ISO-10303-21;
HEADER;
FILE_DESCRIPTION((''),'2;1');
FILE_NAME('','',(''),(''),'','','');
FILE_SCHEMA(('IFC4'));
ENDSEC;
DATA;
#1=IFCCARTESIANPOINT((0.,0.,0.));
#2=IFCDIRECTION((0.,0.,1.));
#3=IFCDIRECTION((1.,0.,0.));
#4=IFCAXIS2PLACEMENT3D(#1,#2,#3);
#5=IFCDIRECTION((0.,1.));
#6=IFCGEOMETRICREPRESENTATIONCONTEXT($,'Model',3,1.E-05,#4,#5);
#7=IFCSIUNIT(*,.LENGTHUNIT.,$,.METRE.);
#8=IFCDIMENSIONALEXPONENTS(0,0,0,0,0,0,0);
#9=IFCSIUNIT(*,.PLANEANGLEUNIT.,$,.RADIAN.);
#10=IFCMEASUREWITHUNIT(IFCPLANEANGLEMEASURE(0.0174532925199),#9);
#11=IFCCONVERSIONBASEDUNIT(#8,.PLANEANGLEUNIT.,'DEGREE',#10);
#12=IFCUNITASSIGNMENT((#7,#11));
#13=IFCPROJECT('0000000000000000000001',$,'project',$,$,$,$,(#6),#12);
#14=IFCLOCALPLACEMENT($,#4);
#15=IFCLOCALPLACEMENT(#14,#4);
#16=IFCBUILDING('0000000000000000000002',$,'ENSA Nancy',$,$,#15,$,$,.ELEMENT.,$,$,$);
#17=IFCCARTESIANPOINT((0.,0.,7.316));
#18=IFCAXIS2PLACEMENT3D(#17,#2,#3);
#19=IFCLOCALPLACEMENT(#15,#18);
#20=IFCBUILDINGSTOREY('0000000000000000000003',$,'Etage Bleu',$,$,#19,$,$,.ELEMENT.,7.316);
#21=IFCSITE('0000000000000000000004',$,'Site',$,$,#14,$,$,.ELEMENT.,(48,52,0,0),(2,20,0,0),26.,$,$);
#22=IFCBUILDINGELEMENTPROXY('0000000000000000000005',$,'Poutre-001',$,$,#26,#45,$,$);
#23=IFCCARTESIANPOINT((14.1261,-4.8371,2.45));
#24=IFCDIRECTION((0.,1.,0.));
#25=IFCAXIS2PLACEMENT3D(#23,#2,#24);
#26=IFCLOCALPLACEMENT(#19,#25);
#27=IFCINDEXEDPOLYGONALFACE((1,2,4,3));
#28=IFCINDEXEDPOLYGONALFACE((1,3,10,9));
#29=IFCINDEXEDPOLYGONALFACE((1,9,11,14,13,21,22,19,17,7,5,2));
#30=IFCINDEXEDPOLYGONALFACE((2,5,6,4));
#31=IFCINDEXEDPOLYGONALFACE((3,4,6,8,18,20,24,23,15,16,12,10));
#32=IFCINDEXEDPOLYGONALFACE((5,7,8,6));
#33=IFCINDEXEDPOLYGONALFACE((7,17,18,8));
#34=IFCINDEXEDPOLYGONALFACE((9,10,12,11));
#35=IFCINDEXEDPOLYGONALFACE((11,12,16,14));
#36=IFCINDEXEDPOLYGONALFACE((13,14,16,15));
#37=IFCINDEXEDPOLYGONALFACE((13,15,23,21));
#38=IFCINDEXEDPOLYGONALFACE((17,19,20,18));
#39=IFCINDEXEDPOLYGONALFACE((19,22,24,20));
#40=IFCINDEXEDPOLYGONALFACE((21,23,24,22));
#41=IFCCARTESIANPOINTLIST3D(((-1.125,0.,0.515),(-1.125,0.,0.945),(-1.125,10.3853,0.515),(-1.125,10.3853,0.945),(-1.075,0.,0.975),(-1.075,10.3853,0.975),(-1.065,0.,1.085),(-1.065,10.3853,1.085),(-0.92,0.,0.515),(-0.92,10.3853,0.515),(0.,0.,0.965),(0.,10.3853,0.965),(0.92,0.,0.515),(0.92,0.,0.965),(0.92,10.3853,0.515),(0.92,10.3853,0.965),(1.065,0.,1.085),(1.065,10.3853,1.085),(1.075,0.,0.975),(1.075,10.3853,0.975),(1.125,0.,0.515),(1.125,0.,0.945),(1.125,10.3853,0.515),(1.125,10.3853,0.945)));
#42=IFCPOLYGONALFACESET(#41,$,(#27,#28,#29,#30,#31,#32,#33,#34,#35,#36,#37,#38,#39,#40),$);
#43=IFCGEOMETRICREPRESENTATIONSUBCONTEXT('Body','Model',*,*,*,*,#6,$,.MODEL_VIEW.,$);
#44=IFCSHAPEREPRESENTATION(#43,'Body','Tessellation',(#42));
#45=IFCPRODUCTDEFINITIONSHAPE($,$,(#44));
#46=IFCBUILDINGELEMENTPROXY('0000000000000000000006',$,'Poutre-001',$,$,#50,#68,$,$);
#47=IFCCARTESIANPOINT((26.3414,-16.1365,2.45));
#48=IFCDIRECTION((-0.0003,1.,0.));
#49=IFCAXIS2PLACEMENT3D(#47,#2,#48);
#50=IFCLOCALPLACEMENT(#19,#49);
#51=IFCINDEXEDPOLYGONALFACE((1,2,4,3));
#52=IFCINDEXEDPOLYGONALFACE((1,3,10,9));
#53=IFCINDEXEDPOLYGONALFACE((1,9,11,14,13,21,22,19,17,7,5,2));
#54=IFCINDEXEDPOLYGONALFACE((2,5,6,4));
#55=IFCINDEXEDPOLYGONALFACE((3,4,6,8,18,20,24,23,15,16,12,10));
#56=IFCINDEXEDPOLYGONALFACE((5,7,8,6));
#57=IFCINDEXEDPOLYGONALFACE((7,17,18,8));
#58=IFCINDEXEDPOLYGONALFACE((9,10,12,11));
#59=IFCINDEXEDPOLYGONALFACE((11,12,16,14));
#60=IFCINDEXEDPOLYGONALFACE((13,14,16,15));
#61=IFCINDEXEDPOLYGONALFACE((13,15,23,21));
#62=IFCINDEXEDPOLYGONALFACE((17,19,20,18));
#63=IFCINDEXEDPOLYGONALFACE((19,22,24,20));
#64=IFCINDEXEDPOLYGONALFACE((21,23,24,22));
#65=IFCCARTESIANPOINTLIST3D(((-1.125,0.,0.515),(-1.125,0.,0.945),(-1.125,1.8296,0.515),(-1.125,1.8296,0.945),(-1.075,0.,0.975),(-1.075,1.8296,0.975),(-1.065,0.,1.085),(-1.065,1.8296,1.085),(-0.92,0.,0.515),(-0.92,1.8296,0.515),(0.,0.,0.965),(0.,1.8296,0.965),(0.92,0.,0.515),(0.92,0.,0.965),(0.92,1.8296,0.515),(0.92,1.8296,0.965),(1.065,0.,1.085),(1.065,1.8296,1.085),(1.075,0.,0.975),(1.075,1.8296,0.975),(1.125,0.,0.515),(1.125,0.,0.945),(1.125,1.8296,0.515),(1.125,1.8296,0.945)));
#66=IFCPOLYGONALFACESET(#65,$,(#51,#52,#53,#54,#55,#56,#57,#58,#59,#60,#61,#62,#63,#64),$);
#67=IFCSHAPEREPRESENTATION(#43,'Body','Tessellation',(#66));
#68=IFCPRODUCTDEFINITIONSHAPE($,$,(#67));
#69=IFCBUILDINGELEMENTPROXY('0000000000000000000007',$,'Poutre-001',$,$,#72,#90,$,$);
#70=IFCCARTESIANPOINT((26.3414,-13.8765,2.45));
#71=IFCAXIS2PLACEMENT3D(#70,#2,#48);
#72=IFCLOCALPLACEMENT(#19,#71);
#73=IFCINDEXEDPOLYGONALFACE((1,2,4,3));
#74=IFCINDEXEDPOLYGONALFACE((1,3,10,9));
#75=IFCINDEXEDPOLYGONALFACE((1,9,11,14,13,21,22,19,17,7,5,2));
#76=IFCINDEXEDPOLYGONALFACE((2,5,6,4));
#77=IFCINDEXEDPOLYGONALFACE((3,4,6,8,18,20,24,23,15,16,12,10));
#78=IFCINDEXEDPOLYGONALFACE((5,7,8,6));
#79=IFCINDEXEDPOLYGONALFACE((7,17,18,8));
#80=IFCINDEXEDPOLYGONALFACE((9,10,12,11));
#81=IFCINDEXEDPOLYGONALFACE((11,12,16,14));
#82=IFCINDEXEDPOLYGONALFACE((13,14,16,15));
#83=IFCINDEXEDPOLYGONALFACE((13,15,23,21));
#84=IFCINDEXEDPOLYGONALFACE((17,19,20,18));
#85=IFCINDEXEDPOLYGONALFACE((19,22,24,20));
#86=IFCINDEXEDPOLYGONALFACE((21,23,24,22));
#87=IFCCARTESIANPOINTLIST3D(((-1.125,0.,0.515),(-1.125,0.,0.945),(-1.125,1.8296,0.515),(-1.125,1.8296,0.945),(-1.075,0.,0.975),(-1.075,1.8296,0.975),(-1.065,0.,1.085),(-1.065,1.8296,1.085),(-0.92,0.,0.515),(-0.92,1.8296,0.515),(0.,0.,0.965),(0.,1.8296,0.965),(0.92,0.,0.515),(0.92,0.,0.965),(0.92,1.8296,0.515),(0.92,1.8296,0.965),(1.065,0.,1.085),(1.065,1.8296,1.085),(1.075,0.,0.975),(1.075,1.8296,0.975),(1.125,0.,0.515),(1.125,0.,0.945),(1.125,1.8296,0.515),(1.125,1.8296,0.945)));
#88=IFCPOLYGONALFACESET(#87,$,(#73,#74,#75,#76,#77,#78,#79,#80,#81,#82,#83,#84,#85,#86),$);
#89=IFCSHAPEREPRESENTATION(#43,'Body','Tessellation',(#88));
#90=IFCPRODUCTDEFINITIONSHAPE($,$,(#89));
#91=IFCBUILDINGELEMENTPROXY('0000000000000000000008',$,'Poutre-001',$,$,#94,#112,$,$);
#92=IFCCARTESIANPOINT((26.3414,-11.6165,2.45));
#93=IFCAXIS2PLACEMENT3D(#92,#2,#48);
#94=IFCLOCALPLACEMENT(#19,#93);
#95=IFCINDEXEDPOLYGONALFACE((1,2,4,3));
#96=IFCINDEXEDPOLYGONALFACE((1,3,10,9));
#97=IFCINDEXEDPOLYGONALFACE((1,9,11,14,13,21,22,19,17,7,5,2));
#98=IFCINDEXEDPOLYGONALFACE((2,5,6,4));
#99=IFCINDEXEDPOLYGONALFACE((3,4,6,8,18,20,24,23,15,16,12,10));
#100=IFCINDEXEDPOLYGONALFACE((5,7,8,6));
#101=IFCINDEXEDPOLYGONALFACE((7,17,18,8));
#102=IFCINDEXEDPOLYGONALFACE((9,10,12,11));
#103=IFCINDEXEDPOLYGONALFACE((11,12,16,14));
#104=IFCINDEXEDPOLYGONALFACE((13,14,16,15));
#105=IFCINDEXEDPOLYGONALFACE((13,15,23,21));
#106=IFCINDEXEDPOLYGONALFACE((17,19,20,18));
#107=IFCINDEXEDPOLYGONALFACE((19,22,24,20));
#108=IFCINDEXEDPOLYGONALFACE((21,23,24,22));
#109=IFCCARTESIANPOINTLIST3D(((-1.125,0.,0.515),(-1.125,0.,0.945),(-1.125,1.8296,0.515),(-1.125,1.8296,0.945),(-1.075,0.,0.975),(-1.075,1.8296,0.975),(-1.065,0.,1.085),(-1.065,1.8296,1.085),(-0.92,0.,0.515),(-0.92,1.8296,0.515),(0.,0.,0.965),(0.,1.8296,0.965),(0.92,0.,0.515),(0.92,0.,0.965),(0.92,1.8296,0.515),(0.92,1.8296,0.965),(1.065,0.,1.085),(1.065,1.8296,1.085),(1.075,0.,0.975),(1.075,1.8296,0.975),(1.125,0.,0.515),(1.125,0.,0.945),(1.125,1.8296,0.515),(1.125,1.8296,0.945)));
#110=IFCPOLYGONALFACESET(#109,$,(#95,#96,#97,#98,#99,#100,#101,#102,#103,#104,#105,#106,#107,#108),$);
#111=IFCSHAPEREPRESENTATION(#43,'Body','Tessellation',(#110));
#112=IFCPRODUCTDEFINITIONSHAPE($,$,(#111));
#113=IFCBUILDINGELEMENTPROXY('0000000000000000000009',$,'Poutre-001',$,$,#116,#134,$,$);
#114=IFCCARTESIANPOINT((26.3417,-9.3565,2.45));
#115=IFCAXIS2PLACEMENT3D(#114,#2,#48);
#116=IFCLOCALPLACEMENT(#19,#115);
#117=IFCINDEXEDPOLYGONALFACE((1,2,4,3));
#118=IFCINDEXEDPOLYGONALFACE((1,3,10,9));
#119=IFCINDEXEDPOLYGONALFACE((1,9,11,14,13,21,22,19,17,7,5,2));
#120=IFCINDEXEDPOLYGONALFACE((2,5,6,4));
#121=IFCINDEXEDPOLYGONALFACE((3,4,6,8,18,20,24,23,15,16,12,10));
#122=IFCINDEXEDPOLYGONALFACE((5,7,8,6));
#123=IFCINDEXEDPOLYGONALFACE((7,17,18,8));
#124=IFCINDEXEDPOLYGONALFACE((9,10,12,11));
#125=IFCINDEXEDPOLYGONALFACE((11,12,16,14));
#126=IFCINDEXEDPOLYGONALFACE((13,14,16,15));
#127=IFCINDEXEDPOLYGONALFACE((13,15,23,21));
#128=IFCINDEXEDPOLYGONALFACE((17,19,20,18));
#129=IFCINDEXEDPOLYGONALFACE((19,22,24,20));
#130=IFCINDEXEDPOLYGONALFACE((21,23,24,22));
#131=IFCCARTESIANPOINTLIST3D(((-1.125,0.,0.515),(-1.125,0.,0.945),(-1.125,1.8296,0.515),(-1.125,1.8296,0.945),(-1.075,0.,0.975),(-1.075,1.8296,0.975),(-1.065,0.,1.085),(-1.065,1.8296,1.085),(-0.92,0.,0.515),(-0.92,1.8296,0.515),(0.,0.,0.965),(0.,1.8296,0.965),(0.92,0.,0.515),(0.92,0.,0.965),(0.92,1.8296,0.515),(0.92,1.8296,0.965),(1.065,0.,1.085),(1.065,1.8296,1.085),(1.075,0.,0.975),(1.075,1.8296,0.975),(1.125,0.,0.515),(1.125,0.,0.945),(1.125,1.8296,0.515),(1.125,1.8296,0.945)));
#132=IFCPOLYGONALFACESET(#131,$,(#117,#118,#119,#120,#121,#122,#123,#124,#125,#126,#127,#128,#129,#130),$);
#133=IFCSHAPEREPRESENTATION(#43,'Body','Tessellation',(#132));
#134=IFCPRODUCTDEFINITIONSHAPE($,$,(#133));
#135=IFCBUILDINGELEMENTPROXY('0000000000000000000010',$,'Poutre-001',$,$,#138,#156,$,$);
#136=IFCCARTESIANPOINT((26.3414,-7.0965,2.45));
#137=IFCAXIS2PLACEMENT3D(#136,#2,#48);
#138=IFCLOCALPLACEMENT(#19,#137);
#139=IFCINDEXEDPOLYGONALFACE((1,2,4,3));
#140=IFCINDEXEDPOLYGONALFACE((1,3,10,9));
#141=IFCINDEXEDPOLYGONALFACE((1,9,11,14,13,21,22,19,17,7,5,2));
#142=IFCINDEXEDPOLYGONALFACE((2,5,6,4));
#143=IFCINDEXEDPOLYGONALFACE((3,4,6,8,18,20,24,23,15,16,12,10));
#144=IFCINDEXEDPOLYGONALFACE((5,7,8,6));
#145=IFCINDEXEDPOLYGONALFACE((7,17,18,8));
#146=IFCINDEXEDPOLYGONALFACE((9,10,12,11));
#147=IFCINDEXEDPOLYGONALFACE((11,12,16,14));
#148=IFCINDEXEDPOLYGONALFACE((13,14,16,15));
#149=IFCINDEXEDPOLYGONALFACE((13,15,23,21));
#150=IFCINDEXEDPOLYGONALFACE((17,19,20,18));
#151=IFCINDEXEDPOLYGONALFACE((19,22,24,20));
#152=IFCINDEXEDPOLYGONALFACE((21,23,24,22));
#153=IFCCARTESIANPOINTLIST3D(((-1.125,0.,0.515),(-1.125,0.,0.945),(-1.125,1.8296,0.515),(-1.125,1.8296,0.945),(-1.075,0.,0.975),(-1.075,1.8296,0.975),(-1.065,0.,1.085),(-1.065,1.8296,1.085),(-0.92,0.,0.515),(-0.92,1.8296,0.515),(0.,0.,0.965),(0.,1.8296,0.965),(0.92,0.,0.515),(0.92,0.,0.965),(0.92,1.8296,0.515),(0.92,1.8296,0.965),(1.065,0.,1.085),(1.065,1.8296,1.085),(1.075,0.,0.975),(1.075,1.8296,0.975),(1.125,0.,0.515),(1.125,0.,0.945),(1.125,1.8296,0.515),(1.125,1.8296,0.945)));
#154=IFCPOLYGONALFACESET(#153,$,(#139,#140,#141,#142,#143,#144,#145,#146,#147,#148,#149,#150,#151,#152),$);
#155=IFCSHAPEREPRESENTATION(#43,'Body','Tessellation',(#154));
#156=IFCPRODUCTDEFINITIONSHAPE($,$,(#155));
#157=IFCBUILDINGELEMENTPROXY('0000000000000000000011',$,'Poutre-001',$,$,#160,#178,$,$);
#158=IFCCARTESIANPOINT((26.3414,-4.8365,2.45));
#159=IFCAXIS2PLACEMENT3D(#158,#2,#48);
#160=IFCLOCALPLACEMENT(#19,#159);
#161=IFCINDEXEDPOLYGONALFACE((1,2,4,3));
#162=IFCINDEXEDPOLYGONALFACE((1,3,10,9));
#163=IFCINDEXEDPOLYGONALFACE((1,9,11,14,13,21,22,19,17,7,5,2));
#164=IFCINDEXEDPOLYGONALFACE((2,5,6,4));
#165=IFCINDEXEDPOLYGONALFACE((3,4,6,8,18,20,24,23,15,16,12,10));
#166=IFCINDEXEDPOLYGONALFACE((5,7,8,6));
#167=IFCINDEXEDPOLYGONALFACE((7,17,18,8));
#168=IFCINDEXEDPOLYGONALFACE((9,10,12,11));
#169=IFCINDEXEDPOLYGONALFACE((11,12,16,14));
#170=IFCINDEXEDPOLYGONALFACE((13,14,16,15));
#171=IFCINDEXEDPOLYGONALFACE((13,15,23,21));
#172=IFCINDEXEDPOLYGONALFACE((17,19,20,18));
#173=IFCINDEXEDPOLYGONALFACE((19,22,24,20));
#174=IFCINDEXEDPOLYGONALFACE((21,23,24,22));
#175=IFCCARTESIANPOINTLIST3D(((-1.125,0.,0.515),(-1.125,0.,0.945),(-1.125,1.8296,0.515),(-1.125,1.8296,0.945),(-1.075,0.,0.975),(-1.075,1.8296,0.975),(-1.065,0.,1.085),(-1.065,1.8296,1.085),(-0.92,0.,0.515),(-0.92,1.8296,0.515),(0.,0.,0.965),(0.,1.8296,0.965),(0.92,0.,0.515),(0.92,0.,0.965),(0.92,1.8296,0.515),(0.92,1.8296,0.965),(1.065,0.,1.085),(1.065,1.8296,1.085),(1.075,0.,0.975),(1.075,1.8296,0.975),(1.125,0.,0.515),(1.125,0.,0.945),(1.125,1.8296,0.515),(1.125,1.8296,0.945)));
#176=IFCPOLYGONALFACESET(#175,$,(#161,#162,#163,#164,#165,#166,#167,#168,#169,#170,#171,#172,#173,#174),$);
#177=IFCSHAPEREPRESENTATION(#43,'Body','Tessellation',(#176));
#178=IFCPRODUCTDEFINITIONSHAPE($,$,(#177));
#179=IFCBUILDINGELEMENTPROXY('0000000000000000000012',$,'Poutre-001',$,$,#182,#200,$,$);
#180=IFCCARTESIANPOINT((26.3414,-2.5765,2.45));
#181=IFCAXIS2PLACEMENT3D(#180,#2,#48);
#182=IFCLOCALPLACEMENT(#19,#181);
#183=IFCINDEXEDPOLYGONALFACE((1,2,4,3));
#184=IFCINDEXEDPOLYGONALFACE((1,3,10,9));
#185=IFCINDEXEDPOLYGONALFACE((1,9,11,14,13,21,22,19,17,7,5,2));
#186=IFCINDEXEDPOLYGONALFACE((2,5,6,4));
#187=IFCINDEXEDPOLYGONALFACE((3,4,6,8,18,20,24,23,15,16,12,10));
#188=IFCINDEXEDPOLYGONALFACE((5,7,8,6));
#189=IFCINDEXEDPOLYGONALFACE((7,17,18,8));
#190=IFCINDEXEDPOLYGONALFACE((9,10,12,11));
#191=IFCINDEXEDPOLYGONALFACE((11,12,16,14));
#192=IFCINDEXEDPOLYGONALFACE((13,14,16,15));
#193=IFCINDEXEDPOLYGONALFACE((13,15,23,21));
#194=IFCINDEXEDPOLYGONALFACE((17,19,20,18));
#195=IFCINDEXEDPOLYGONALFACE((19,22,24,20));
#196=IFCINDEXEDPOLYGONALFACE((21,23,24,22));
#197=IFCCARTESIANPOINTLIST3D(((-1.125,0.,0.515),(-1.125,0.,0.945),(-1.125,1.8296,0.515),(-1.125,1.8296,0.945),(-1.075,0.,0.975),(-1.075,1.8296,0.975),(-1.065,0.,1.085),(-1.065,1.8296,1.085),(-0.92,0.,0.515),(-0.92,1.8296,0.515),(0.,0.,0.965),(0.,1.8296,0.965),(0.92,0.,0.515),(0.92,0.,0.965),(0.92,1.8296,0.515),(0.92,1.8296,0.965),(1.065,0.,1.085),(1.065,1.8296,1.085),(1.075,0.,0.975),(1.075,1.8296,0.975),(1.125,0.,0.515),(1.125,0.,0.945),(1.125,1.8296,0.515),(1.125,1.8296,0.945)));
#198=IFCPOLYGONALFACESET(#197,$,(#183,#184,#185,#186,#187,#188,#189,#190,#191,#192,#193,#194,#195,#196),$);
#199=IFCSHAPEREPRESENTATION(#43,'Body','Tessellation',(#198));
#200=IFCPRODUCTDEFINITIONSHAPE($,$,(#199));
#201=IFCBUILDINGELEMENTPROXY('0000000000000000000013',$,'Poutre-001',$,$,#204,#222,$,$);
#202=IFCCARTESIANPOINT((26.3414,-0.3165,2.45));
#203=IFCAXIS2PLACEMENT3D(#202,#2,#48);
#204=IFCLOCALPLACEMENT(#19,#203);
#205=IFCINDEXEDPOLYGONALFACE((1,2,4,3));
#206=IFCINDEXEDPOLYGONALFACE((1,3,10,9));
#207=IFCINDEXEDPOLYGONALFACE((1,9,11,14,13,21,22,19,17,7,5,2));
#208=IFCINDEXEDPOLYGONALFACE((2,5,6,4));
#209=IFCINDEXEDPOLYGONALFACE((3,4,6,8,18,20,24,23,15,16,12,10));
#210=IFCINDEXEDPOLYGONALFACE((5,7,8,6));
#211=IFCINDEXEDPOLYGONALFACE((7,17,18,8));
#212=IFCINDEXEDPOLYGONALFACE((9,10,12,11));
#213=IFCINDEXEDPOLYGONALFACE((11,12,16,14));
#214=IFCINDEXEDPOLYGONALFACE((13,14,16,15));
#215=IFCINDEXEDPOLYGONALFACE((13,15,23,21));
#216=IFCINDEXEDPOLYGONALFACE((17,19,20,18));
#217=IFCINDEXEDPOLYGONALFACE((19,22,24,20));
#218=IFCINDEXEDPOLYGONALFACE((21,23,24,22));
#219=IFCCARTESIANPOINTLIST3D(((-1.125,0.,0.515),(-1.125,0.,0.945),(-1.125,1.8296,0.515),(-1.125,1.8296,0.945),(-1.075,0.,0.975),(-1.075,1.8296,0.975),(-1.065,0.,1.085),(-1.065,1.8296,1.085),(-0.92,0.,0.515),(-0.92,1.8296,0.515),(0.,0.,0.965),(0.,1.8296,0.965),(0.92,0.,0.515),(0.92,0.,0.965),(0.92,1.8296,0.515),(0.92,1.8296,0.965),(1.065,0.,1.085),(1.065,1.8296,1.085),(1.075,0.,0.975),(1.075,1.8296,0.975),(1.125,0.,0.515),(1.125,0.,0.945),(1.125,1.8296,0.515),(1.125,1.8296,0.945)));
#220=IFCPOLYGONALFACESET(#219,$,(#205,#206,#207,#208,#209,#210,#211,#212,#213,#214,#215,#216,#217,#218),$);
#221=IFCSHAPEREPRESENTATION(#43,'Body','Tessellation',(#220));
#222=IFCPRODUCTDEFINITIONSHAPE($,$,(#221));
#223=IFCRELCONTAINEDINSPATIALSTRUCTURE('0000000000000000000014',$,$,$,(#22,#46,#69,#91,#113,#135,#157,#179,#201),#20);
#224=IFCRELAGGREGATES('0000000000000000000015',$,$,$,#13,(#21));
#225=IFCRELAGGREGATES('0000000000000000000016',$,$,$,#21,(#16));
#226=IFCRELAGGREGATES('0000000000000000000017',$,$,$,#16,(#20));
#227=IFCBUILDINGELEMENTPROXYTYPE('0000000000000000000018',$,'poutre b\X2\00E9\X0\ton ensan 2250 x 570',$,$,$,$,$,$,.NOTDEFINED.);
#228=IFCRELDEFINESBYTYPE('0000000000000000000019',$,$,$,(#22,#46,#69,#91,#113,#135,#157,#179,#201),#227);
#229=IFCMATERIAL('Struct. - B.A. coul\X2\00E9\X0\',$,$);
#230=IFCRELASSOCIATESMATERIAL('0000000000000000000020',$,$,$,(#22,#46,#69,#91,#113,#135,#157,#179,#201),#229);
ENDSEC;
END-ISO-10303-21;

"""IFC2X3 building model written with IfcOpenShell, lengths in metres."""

from ifc_helpers import new_model, entity, si_unit, converted_unit, direction, frame, origin_with_axes, place, context, subcontext, project, spatial, polyline, outline, extrude, material, type_object, element, save


model = new_model("IFC2X3")

# Units and contexts
model_context = context("Model", 3, precision=1e-05, world=origin_with_axes(), true_north=direction((0.0, 1.0)))
body_context = subcontext(model_context, "Body", "Model", "MODEL_VIEW")
ifc_project = project(units=[si_unit("LENGTHUNIT", "METRE"), converted_unit("PLANEANGLEUNIT", "DEGREE", entity("IfcPlaneAngleMeasure", 0.0174532925199), si_unit("PLANEANGLEUNIT", "RADIAN"), dimensions=[0, 0, 0, 0, 0, 0, 0])], contexts=[model_context])

# Site, building, storey
site_placement = place(None, origin_with_axes())
site = spatial("IfcSite", under=ifc_project, at=site_placement, Name="Site", CompositionType="ELEMENT", RefLatitude=(48, 52, 0, 0), RefLongitude=(2, 20, 0, 0), RefElevation=26.0)
building_placement = place(site_placement, origin_with_axes())
building = spatial("IfcBuilding", under=site, at=building_placement, Name="ENSA Nancy", CompositionType="ELEMENT")
storey_placement = place(building_placement, frame((0.0, 0.0, 7.316), z_axis=(0.0, 0.0, 1.0), x_axis=(1.0, 0.0, 0.0)))
storey = spatial("IfcBuildingStorey", under=building, at=storey_placement, Name="Etage Bleu", CompositionType="ELEMENT", Elevation=7.316)

# Building element proxies
ifc_material = material(Name="Struct. - B.A. coulé")
building_element_proxy_type = type_object("IfcBuildingElementProxyType", Name="poutre béton ensan 2250 x 570", PredefinedType="NOTDEFINED")
proxy_1_placement = place(storey_placement, frame((14.1261, -4.8371, 2.45), z_axis=(0.0, 0.0, 1.0), x_axis=(0.0, 1.0, 0.0)))
element("IfcBuildingElementProxy", 1, at=proxy_1_placement, inside=storey, type_object=building_element_proxy_type, material=ifc_material, Name="Poutre-001", context=body_context, shape_type="SweptSolid", body=[
    extrude(outline(polyline([(-1.065, 1.085), (-1.075, 0.975), (-1.125, 0.945), (-1.125, 0.515), (-0.92, 0.515), (0.0, 0.965), (0.92, 0.965), (0.92, 0.515), (1.125, 0.515), (1.125, 0.945), (1.075, 0.975), (1.065, 1.085), (-1.065, 1.085)])), frame((0.0, 10.3853, 0.0), z_axis=(0.0, -1.0, 0.0), x_axis=(1.0, 0.0, 0.0)), (0.0, 0.0, 1.0), 10.3853),
])
for number, where, z_axis, x_axis, name in (
    (2, (26.3414, -16.1365, 2.45), (0.0, 0.0, 1.0), (-0.0003, 1.0, 0.0), "Poutre-001"),
    (3, (26.3414, -13.8765, 2.45), (0.0, 0.0, 1.0), (-0.0003, 1.0, 0.0), "Poutre-001"),
    (4, (26.3414, -11.6165, 2.45), (0.0, 0.0, 1.0), (-0.0003, 1.0, 0.0), "Poutre-001"),
    (5, (26.3417, -9.3565, 2.45), (0.0, 0.0, 1.0), (-0.0003, 1.0, 0.0), "Poutre-001"),
    (6, (26.3414, -7.0965, 2.45), (0.0, 0.0, 1.0), (-0.0003, 1.0, 0.0), "Poutre-001"),
    (7, (26.3414, -4.8365, 2.45), (0.0, 0.0, 1.0), (-0.0003, 1.0, 0.0), "Poutre-001"),
    (8, (26.3414, -2.5765, 2.45), (0.0, 0.0, 1.0), (-0.0003, 1.0, 0.0), "Poutre-001"),
    (9, (26.3414, -0.3165, 2.45), (0.0, 0.0, 1.0), (-0.0003, 1.0, 0.0), "Poutre-001"),
):
    element("IfcBuildingElementProxy", number, at=place(storey_placement, frame(where, z_axis=z_axis, x_axis=x_axis)), inside=storey, type_object=building_element_proxy_type, material=ifc_material, Name=name, context=body_context, shape_type="SweptSolid", body=[
        extrude(outline(polyline([(-1.065, 1.085), (-1.075, 0.975), (-1.125, 0.945), (-1.125, 0.515), (-0.92, 0.515), (0.0, 0.965), (0.92, 0.965), (0.92, 0.515), (1.125, 0.515), (1.125, 0.945), (1.075, 0.975), (1.065, 1.085), (-1.065, 1.085)])), frame((0.0, 1.8296, 0.0), z_axis=(0.0, -1.0, 0.0), x_axis=(1.0, 0.0, 0.0)), (0.0, 0.0, 1.0), 1.8296),
    ])

save(model, "model.ifc")
